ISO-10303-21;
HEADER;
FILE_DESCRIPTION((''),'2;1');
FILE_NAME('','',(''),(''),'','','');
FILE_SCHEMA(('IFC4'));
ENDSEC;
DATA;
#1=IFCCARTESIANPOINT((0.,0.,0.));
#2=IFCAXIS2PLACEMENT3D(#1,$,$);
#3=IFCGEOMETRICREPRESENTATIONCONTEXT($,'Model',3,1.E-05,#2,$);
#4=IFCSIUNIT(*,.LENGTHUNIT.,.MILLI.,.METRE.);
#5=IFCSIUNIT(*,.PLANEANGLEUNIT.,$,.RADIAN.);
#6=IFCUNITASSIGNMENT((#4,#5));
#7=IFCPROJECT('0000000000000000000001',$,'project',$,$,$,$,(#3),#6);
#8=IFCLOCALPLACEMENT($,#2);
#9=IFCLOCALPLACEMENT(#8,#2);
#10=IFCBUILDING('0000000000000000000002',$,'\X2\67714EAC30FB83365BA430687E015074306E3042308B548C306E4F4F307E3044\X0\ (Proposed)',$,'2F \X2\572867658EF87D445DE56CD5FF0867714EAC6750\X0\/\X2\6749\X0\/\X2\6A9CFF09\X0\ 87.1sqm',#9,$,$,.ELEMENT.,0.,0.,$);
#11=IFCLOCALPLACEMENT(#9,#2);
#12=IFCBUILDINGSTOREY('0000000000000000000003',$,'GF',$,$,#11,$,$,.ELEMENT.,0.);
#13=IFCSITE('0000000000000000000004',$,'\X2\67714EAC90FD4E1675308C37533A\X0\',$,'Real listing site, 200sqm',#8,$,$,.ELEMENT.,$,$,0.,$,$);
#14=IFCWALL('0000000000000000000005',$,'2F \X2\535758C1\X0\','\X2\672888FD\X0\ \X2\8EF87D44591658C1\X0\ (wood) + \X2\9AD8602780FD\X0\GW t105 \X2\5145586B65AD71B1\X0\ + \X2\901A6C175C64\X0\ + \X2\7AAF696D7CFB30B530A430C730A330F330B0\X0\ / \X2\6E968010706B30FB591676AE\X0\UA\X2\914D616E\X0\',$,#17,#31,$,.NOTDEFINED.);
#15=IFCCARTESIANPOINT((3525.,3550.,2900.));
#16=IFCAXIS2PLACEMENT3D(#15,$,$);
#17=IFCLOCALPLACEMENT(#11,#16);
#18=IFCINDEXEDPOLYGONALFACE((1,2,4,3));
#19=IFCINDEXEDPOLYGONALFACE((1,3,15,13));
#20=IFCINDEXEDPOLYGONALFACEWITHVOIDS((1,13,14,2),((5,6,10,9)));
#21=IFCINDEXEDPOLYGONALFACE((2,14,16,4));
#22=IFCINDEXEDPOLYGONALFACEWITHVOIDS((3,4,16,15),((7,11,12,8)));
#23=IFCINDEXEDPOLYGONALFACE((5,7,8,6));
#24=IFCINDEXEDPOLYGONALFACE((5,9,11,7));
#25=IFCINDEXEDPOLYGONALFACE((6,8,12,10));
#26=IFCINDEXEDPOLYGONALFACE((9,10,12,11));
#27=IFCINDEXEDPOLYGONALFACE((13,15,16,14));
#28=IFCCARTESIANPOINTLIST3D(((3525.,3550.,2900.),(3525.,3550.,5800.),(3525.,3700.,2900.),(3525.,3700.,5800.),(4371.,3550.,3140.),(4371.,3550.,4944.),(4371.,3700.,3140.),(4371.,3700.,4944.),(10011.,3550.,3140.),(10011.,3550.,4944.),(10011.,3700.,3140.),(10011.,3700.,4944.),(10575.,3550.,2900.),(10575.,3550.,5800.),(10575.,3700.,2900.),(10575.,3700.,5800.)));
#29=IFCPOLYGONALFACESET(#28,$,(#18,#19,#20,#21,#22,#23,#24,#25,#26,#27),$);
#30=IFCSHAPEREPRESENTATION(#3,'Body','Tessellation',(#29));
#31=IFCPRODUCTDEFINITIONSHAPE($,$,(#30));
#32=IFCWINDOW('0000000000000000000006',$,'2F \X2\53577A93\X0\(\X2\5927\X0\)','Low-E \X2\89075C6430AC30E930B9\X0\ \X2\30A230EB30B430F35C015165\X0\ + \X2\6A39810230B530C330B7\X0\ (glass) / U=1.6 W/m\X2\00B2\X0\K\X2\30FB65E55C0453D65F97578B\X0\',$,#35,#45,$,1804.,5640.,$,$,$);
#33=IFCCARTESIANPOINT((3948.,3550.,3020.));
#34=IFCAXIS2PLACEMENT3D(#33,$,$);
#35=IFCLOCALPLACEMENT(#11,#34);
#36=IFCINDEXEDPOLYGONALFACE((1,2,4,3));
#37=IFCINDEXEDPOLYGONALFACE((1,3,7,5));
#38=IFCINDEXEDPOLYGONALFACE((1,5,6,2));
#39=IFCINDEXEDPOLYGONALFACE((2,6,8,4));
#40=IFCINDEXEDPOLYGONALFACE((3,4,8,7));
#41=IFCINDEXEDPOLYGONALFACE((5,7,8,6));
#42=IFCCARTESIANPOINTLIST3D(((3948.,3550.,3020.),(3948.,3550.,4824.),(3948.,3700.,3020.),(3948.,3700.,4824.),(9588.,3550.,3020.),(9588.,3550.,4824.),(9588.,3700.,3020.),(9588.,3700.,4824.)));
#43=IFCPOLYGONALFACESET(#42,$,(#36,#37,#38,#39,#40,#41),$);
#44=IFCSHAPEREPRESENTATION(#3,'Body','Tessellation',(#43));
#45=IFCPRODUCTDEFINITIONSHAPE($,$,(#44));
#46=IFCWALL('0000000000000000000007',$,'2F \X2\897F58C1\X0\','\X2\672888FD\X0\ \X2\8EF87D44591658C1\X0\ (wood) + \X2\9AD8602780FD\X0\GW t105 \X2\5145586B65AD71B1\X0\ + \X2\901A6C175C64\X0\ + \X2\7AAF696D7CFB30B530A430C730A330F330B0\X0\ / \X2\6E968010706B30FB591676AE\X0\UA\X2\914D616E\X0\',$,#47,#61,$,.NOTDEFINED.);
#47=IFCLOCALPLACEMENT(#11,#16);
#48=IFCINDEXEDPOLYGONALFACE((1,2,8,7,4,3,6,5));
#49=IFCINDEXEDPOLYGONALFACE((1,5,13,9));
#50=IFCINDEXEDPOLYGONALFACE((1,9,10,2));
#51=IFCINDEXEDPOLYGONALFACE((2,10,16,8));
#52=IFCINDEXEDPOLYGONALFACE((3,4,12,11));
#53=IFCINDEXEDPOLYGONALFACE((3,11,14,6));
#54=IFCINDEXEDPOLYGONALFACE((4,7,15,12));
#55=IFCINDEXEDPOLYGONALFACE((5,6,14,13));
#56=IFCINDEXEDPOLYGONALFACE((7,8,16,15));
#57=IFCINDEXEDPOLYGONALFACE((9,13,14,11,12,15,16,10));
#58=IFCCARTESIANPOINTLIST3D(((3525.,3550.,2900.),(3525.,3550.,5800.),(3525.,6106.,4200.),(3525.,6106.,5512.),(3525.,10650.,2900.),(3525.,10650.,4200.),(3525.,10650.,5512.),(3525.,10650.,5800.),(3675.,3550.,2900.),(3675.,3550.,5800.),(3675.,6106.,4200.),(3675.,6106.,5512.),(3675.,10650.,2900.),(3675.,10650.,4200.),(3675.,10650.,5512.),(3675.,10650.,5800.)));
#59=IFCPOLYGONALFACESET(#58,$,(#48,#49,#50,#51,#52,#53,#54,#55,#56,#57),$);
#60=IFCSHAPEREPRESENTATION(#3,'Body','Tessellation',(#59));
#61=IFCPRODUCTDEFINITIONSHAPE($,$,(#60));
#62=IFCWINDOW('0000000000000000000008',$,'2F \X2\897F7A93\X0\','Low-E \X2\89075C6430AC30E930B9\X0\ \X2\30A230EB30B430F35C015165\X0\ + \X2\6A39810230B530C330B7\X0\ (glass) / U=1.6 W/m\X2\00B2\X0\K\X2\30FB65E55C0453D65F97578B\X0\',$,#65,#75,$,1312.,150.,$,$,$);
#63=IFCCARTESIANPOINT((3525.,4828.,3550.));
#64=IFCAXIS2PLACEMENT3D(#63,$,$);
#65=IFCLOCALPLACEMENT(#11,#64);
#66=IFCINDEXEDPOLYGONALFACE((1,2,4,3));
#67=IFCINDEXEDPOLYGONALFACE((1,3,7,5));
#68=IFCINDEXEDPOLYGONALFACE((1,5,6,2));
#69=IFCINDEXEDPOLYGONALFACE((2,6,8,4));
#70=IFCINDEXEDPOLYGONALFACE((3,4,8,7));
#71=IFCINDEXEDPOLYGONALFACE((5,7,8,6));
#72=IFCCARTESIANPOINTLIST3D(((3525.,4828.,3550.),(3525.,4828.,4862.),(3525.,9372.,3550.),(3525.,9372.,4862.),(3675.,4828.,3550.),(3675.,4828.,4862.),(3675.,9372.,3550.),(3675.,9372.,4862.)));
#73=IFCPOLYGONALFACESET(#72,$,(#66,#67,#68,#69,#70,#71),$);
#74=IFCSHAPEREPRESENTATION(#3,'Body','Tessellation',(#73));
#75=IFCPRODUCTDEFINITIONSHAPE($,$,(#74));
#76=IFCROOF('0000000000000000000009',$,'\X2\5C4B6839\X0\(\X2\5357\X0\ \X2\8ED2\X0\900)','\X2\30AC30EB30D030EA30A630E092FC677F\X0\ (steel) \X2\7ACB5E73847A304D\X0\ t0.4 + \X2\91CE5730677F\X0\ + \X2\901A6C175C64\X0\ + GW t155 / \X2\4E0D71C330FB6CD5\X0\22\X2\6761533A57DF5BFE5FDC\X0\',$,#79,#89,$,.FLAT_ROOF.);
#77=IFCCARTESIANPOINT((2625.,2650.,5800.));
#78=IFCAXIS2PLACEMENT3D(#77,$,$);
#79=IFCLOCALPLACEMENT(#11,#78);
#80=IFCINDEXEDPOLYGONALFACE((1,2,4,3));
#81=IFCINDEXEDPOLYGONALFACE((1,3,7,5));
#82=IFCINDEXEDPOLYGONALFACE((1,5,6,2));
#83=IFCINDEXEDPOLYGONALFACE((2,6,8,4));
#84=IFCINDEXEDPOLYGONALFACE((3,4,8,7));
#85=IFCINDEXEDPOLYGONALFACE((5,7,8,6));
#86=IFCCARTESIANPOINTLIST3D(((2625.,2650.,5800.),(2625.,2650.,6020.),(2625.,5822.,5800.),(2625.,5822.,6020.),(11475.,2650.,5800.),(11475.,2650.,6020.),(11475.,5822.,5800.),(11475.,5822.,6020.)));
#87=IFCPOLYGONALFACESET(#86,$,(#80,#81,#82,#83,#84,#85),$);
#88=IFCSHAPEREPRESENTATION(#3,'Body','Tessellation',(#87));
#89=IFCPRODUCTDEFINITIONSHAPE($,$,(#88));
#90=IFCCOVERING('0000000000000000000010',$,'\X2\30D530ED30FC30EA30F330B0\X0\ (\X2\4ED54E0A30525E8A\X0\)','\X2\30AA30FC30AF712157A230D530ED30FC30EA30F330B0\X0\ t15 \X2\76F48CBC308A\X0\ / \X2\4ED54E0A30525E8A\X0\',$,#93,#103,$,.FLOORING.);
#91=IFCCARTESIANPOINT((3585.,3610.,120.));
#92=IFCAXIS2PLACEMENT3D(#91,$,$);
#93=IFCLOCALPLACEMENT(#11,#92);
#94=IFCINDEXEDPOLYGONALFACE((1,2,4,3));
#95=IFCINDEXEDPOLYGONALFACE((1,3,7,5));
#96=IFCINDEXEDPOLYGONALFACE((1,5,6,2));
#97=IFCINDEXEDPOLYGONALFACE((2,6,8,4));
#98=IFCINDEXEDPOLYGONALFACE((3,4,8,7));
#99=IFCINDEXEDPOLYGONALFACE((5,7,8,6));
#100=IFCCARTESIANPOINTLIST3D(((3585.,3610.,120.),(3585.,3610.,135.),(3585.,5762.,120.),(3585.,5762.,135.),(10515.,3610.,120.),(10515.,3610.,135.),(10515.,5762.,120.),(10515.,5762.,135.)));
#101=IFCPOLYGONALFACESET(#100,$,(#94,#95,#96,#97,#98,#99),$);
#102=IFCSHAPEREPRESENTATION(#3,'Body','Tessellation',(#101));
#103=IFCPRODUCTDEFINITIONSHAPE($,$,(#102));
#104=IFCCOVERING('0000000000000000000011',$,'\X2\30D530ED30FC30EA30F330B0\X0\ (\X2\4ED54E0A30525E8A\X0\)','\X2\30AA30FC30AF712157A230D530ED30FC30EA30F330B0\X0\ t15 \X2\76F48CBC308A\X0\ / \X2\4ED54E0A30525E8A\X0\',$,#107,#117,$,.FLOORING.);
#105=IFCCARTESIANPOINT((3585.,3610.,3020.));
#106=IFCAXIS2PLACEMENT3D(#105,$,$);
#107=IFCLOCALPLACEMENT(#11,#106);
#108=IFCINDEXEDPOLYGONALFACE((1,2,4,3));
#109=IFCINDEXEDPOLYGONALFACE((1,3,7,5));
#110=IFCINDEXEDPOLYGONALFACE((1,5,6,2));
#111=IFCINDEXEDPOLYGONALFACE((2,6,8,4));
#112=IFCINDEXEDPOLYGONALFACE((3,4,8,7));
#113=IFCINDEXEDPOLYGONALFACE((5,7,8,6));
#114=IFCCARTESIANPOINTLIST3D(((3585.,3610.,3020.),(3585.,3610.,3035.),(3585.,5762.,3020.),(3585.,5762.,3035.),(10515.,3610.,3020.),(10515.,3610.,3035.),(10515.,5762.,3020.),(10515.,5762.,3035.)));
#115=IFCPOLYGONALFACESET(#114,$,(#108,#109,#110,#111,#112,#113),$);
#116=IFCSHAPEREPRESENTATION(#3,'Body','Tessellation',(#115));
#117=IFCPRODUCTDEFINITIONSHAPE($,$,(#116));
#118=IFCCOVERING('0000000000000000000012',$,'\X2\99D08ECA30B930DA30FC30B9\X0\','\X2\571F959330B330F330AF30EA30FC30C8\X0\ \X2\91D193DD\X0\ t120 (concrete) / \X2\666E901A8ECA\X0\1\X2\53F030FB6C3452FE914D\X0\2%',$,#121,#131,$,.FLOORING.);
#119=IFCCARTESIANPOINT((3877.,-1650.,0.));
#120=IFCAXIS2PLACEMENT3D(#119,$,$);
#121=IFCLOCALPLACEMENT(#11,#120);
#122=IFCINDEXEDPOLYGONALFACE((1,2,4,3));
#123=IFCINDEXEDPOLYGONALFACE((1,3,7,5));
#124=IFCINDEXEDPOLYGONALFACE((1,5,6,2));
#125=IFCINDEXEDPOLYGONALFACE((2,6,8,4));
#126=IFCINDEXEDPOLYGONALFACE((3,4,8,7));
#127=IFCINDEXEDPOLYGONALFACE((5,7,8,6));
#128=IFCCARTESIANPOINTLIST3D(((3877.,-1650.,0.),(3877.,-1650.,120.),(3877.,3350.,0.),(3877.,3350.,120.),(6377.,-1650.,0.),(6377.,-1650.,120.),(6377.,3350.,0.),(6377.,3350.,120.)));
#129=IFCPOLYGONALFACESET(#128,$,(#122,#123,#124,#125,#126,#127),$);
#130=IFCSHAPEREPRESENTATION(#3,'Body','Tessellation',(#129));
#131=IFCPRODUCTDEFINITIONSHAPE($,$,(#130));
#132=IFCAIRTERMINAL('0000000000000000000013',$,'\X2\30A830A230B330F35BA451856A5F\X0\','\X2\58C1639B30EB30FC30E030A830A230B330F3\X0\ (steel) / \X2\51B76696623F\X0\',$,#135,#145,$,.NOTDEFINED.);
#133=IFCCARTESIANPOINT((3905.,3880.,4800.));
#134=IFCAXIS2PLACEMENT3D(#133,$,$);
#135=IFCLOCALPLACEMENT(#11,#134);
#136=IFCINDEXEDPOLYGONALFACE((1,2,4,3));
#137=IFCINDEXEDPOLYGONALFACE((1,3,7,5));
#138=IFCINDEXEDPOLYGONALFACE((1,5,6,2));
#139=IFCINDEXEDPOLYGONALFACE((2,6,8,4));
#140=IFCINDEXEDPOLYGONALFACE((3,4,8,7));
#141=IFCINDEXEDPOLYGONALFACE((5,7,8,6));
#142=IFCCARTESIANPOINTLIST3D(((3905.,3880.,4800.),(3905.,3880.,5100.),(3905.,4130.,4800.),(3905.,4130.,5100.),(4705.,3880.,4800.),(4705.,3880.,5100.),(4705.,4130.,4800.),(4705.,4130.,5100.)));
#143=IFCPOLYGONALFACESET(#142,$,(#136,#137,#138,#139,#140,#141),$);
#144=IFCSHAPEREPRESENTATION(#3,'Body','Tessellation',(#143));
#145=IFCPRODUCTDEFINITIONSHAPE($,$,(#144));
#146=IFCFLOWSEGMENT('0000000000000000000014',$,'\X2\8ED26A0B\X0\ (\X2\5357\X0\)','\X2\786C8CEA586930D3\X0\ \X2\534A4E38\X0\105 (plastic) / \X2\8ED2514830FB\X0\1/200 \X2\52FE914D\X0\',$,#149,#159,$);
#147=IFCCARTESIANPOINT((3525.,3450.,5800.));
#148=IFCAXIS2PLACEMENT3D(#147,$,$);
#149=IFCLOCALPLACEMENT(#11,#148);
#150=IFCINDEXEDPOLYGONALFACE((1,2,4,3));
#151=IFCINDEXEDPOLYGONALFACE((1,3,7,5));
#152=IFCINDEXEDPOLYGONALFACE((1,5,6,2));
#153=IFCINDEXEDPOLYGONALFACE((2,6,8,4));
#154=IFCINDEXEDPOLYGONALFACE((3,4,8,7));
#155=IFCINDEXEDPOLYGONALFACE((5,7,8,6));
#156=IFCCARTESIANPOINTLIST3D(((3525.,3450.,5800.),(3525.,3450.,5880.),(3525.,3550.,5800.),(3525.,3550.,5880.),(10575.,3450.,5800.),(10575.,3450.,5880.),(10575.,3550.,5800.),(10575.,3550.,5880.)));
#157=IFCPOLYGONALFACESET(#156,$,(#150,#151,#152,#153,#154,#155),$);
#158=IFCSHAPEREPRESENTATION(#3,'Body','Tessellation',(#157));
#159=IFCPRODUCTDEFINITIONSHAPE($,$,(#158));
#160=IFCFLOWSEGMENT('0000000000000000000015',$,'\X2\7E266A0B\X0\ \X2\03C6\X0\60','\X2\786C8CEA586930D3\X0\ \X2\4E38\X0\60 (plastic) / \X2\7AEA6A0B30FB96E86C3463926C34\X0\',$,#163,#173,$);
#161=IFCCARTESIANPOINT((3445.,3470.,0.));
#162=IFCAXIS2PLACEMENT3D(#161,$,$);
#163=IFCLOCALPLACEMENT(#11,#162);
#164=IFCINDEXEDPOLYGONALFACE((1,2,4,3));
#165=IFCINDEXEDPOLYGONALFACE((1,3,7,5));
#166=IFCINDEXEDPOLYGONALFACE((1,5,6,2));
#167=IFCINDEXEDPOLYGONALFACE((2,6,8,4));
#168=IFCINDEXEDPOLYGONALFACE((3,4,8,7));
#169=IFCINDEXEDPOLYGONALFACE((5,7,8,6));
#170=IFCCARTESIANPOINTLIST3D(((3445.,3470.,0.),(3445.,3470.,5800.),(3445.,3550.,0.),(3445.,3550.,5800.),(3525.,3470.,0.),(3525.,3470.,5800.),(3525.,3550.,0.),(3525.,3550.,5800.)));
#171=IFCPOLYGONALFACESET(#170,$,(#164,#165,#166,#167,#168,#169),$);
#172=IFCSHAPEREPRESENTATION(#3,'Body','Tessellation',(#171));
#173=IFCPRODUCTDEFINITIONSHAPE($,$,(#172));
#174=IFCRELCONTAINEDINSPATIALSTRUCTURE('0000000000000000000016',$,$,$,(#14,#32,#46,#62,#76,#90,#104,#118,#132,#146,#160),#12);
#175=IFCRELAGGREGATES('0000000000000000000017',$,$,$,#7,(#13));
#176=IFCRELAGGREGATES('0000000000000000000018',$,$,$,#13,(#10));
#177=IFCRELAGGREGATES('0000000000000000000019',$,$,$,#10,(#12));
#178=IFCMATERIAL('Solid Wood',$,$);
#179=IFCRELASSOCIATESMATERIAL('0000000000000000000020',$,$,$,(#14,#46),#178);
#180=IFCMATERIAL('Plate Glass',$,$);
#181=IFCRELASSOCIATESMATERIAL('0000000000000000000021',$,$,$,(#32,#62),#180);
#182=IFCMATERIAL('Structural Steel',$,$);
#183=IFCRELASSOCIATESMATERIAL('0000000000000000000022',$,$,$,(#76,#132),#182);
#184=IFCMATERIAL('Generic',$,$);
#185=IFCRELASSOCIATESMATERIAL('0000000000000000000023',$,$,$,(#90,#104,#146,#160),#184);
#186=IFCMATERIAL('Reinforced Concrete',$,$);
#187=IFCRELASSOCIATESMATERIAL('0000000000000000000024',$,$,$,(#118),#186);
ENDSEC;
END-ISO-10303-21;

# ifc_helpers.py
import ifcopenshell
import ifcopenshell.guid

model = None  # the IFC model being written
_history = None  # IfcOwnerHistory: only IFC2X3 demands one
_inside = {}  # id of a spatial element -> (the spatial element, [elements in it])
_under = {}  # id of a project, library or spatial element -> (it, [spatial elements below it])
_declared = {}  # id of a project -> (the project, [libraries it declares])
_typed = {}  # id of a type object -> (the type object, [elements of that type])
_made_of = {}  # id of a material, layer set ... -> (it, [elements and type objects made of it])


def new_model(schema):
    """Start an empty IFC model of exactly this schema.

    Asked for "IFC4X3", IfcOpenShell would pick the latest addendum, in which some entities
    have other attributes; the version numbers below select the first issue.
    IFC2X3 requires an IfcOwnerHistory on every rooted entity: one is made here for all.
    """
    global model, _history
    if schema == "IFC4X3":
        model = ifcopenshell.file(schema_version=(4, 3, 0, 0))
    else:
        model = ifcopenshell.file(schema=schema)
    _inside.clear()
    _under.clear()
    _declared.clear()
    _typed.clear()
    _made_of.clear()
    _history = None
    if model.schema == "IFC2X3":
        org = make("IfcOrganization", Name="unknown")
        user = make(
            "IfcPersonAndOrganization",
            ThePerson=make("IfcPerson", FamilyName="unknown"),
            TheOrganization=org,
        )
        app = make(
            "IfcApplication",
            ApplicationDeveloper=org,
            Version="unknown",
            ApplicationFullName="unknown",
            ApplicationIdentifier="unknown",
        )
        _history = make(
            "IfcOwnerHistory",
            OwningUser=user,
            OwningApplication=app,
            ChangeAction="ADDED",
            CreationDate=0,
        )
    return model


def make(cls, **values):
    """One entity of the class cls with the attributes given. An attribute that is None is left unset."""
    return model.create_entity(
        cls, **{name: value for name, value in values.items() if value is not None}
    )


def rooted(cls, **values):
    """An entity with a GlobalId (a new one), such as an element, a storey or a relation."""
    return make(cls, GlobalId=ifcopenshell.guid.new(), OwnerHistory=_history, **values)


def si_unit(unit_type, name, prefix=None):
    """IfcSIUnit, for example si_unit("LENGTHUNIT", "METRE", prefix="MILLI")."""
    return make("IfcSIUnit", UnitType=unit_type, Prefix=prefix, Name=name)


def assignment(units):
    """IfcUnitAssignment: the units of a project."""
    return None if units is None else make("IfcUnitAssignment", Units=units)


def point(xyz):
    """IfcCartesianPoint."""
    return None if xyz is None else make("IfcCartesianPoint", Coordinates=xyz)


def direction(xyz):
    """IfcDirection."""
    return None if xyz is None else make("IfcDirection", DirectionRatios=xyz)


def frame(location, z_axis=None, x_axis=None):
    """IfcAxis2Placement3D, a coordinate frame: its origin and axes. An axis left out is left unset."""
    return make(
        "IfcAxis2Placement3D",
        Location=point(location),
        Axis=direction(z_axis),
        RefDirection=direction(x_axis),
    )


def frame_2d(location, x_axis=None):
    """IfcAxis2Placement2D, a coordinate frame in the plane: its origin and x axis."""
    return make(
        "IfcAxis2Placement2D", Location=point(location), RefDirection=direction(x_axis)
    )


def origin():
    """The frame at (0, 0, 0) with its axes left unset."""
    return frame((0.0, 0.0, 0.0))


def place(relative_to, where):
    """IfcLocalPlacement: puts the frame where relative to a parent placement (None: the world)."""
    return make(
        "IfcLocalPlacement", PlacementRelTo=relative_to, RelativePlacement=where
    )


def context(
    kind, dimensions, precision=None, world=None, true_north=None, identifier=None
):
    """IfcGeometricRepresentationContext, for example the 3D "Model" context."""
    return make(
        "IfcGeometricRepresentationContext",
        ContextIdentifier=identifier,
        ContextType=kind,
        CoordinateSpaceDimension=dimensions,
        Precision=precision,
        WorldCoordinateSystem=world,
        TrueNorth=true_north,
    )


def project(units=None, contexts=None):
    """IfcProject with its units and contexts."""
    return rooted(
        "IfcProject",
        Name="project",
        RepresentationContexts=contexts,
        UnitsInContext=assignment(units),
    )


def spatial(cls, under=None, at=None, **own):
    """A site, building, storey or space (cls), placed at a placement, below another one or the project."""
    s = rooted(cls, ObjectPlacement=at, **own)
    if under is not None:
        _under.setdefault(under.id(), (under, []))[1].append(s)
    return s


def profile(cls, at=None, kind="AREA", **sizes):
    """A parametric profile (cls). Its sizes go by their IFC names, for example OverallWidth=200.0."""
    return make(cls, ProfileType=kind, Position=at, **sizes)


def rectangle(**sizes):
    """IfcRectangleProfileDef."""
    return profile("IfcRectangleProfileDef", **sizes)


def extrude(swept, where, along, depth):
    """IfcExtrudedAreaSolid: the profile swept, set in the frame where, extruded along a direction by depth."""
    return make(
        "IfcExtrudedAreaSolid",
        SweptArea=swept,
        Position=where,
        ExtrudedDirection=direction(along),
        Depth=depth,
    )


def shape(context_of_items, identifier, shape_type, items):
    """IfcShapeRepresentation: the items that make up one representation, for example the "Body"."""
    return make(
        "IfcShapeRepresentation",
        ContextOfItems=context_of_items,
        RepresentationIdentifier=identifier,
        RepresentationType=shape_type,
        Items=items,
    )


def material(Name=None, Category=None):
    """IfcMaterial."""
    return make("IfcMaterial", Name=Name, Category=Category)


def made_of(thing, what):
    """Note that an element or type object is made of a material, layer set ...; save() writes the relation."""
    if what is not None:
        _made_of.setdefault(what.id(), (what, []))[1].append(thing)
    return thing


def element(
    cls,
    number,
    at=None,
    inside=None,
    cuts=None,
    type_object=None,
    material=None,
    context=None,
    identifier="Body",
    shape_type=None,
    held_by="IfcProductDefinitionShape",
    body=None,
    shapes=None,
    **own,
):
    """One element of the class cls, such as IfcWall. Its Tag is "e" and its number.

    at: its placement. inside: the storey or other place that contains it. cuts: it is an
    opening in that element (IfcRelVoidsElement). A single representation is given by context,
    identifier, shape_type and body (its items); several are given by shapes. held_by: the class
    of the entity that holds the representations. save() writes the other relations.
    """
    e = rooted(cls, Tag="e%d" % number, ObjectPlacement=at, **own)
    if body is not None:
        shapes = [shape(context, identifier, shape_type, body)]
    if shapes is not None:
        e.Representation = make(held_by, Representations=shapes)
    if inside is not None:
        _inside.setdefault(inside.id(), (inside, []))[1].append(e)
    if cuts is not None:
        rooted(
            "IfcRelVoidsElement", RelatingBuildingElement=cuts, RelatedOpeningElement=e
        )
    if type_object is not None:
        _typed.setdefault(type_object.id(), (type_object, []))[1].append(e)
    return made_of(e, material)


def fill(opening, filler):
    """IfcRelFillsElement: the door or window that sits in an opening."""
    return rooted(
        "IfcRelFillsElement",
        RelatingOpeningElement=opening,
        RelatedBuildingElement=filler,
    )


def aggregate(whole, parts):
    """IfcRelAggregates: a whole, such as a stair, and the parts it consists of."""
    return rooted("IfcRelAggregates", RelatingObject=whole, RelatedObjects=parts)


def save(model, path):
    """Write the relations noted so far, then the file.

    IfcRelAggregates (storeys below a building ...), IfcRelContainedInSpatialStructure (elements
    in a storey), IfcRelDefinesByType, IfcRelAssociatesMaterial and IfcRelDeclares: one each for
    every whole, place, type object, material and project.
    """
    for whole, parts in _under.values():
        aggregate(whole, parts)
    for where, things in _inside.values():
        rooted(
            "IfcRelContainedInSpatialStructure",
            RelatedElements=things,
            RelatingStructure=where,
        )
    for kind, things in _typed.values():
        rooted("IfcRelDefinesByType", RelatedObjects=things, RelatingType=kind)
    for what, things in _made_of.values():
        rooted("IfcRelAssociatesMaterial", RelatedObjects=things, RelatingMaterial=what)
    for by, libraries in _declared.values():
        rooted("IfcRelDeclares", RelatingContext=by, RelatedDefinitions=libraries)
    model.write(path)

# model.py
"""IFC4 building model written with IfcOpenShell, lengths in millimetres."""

from ifc_helpers import new_model, si_unit, frame, frame_2d, origin, place, context, project, spatial, rectangle, extrude, material, element, fill, save


model = new_model("IFC4")

# Units and contexts
model_context = context("Model", 3, precision=1e-05, world=origin())
ifc_project = project(units=[si_unit("LENGTHUNIT", "METRE", prefix="MILLI"), si_unit("PLANEANGLEUNIT", "RADIAN")], contexts=[model_context])

# Site, building, storey
site_placement = place(None, origin())
site = spatial("IfcSite", under=ifc_project, at=site_placement, Name="東京都世田谷区", ObjectType="Real listing site, 200sqm", CompositionType="ELEMENT", RefElevation=0.0)
building_placement = place(site_placement, origin())
building = spatial("IfcBuilding", under=site, at=building_placement, Name="東京・茶室と縁側のある和の住まい (Proposed)", ObjectType="2F 在来軸組工法（東京材/杉/檜） 87.1sqm", CompositionType="ELEMENT", ElevationOfRefHeight=0.0, ElevationOfTerrain=0.0)
storey_placement = place(building_placement, origin())
storey = spatial("IfcBuildingStorey", under=building, at=storey_placement, Name="GF", CompositionType="ELEMENT", Elevation=0.0)

# Shared definitions
ifc_material_1 = material(Name="Solid Wood")

# Shared definitions
ifc_material_2 = material(Name="Reinforced Concrete")

# Shared definitions
ifc_material_3 = material(Name="Plate Glass")

# Walls, openings, windows
wall_1_placement = place(storey_placement, frame((3525.0, 3550.0, 2900.0)))
wall_1 = element("IfcWall", 1, at=wall_1_placement, inside=storey, material=ifc_material_1, Name="2F 南壁", Description="木製 軸組外壁 (wood) + 高性能GW t105 充填断熱 + 通気層 + 窯業系サイディング / 準耐火・外皮UA配慮", PredefinedType="NOTDEFINED", context=model_context, shape_type="SweptSolid", body=[
    extrude(rectangle(XDim=7050.0, YDim=150.0, at=frame_2d((3525.0, 75.0))), frame((3525.0, 3550.0, 2900.0)), (0.0, 0.0, 1.0), 2900.0),
])
opening_1_placement = place(storey_placement, frame((3948.0, 3550.0, 3020.0)))
opening_1 = element("IfcOpeningElement", 2, at=opening_1_placement, cuts=wall_1, PredefinedType="NOTDEFINED", context=model_context, shape_type="SweptSolid", body=[
    extrude(rectangle(XDim=5640.0, YDim=150.0, at=frame_2d((2820.0, 75.0))), frame((3948.0, 3550.0, 3020.0)), (0.0, 0.0, 1.0), 1804.0),
])
window_1_placement = place(storey_placement, frame((3948.0, 3550.0, 3020.0)))
window_1 = element("IfcWindow", 3, at=window_1_placement, inside=storey, material=ifc_material_3, Name="2F 南窓(大)", Description="Low-E 複層ガラス アルゴン封入 + 樹脂サッシ (glass) / U=1.6 W/m²K・日射取得型", OverallHeight=1804.0, OverallWidth=5640.0, context=model_context, shape_type="SweptSolid", body=[
    extrude(rectangle(XDim=5640.0, YDim=150.0, at=frame_2d((2820.0, 75.0))), frame((3948.0, 3550.0, 3020.0)), (0.0, 0.0, 1.0), 1804.0),
])
fill(opening_1, window_1)
wall_2_placement = place(storey_placement, frame((3525.0, 3550.0, 2900.0)))
wall_2 = element("IfcWall", 4, at=wall_2_placement, inside=storey, material=ifc_material_1, Name="2F 西壁", Description="木製 軸組外壁 (wood) + 高性能GW t105 充填断熱 + 通気層 + 窯業系サイディング / 準耐火・外皮UA配慮", PredefinedType="NOTDEFINED", context=model_context, shape_type="SweptSolid", body=[
    extrude(rectangle(XDim=150.0, YDim=7100.0, at=frame_2d((75.0, 3550.0))), frame((3525.0, 3550.0, 2900.0)), (0.0, 0.0, 1.0), 2900.0),
])
opening_2_placement = place(storey_placement, frame((3525.0, 4828.0, 3550.0)))
opening_2 = element("IfcOpeningElement", 5, at=opening_2_placement, cuts=wall_2, PredefinedType="NOTDEFINED", context=model_context, shape_type="SweptSolid", body=[
    extrude(rectangle(XDim=150.0, YDim=4544.0, at=frame_2d((75.0, 2272.0))), frame((3525.0, 4828.0, 3550.0)), (0.0, 0.0, 1.0), 1312.0),
])
window_2_placement = place(storey_placement, frame((3525.0, 4828.0, 3550.0)))
window_2 = element("IfcWindow", 6, at=window_2_placement, inside=storey, material=ifc_material_3, Name="2F 西窓", Description="Low-E 複層ガラス アルゴン封入 + 樹脂サッシ (glass) / U=1.6 W/m²K・日射取得型", OverallHeight=1312.0, OverallWidth=150.0, context=model_context, shape_type="SweptSolid", body=[
    extrude(rectangle(XDim=150.0, YDim=4544.0, at=frame_2d((75.0, 2272.0))), frame((3525.0, 4828.0, 3550.0)), (0.0, 0.0, 1.0), 1312.0),
])
fill(opening_2, window_2)

# Roof
ifc_material_4 = material(Name="Structural Steel")
for number, where, name in (
    (7, (2625.0, 2650.0, 5800.0), "屋根(南 軒900)"),
):
    element("IfcRoof", number, at=place(storey_placement, frame(where)), inside=storey, material=ifc_material_4, Name=name, Description="ガルバリウム鋼板 (steel) 立平葺き t0.4 + 野地板 + 通気層 + GW t155 / 不燃・法22条区域対応", PredefinedType="FLAT_ROOF", context=model_context, shape_type="SweptSolid", body=[
        extrude(rectangle(XDim=8850.0, YDim=3172.0, at=frame_2d((4425.0, 1586.0))), frame((2625.0, 2650.0, 5800.0)), (0.0, 0.0, 1.0), 220.0),
    ])

# Coverings
ifc_material_5 = material(Name="Generic")
covering_1_placement = place(storey_placement, frame((3585.0, 3610.0, 120.0)))
element("IfcCovering", 8, at=covering_1_placement, inside=storey, material=ifc_material_5, Name="フローリング (仕上げ床)", Description="オーク無垢フローリング t15 直貼り / 仕上げ床", PredefinedType="FLOORING", context=model_context, shape_type="SweptSolid", body=[
    extrude(rectangle(XDim=6930.0, YDim=2152.0, at=frame_2d((3465.0, 1076.0))), frame((3585.0, 3610.0, 120.0)), (0.0, 0.0, 1.0), 15.0),
])
covering_2_placement = place(storey_placement, frame((3585.0, 3610.0, 3020.0)))
element("IfcCovering", 9, at=covering_2_placement, inside=storey, material=ifc_material_5, Name="フローリング (仕上げ床)", Description="オーク無垢フローリング t15 直貼り / 仕上げ床", PredefinedType="FLOORING", context=model_context, shape_type="SweptSolid", body=[
    extrude(rectangle(XDim=6930.0, YDim=2152.0, at=frame_2d((3465.0, 1076.0))), frame((3585.0, 3610.0, 3020.0)), (0.0, 0.0, 1.0), 15.0),
])
covering_3_placement = place(storey_placement, frame((3877.0, -1650.0, 0.0)))
element("IfcCovering", 10, at=covering_3_placement, inside=storey, material=ifc_material_2, Name="駐車スペース", Description="土間コンクリート 金鏝 t120 (concrete) / 普通車1台・水勾配2%", PredefinedType="FLOORING", context=model_context, shape_type="SweptSolid", body=[
    extrude(rectangle(XDim=2500.0, YDim=5000.0, at=frame_2d((1250.0, 2500.0))), frame((3877.0, -1650.0, 0.0)), (0.0, 0.0, 1.0), 120.0),
])

# Air terminal
air_terminal_placement = place(storey_placement, frame((3905.0, 3880.0, 4800.0)))
element("IfcAirTerminal", 11, at=air_terminal_placement, inside=storey, material=ifc_material_4, Name="エアコン室内機", Description="壁掛ルームエアコン (steel) / 冷暖房", PredefinedType="NOTDEFINED", context=model_context, shape_type="SweptSolid", body=[
    extrude(rectangle(XDim=800.0, YDim=250.0, at=frame_2d((400.0, 125.0))), frame((3905.0, 3880.0, 4800.0)), (0.0, 0.0, 1.0), 300.0),
])

# Flow segments
flow_segment_1_placement = place(storey_placement, frame((3525.0, 3450.0, 5800.0)))
element("IfcFlowSegment", 12, at=flow_segment_1_placement, inside=storey, material=ifc_material_5, Name="軒樋 (南)", Description="硬質塩ビ 半丸105 (plastic) / 軒先・1/200 勾配", context=model_context, shape_type="SweptSolid", body=[
    extrude(rectangle(XDim=7050.0, YDim=100.0, at=frame_2d((3525.0, 50.0))), frame((3525.0, 3450.0, 5800.0)), (0.0, 0.0, 1.0), 80.0),
])
flow_segment_2_placement = place(storey_placement, frame((3445.0, 3470.0, 0.0)))
element("IfcFlowSegment", 13, at=flow_segment_2_placement, inside=storey, material=ifc_material_5, Name="縦樋 φ60", Description="硬質塩ビ 丸60 (plastic) / 竪樋・雨水排水", context=model_context, shape_type="SweptSolid", body=[
    extrude(rectangle(XDim=80.0, YDim=80.0, at=frame_2d((40.0, 40.0))), frame((3445.0, 3470.0, 0.0)), (0.0, 0.0, 1.0), 5800.0),
])

save(model, "model.ifc")
